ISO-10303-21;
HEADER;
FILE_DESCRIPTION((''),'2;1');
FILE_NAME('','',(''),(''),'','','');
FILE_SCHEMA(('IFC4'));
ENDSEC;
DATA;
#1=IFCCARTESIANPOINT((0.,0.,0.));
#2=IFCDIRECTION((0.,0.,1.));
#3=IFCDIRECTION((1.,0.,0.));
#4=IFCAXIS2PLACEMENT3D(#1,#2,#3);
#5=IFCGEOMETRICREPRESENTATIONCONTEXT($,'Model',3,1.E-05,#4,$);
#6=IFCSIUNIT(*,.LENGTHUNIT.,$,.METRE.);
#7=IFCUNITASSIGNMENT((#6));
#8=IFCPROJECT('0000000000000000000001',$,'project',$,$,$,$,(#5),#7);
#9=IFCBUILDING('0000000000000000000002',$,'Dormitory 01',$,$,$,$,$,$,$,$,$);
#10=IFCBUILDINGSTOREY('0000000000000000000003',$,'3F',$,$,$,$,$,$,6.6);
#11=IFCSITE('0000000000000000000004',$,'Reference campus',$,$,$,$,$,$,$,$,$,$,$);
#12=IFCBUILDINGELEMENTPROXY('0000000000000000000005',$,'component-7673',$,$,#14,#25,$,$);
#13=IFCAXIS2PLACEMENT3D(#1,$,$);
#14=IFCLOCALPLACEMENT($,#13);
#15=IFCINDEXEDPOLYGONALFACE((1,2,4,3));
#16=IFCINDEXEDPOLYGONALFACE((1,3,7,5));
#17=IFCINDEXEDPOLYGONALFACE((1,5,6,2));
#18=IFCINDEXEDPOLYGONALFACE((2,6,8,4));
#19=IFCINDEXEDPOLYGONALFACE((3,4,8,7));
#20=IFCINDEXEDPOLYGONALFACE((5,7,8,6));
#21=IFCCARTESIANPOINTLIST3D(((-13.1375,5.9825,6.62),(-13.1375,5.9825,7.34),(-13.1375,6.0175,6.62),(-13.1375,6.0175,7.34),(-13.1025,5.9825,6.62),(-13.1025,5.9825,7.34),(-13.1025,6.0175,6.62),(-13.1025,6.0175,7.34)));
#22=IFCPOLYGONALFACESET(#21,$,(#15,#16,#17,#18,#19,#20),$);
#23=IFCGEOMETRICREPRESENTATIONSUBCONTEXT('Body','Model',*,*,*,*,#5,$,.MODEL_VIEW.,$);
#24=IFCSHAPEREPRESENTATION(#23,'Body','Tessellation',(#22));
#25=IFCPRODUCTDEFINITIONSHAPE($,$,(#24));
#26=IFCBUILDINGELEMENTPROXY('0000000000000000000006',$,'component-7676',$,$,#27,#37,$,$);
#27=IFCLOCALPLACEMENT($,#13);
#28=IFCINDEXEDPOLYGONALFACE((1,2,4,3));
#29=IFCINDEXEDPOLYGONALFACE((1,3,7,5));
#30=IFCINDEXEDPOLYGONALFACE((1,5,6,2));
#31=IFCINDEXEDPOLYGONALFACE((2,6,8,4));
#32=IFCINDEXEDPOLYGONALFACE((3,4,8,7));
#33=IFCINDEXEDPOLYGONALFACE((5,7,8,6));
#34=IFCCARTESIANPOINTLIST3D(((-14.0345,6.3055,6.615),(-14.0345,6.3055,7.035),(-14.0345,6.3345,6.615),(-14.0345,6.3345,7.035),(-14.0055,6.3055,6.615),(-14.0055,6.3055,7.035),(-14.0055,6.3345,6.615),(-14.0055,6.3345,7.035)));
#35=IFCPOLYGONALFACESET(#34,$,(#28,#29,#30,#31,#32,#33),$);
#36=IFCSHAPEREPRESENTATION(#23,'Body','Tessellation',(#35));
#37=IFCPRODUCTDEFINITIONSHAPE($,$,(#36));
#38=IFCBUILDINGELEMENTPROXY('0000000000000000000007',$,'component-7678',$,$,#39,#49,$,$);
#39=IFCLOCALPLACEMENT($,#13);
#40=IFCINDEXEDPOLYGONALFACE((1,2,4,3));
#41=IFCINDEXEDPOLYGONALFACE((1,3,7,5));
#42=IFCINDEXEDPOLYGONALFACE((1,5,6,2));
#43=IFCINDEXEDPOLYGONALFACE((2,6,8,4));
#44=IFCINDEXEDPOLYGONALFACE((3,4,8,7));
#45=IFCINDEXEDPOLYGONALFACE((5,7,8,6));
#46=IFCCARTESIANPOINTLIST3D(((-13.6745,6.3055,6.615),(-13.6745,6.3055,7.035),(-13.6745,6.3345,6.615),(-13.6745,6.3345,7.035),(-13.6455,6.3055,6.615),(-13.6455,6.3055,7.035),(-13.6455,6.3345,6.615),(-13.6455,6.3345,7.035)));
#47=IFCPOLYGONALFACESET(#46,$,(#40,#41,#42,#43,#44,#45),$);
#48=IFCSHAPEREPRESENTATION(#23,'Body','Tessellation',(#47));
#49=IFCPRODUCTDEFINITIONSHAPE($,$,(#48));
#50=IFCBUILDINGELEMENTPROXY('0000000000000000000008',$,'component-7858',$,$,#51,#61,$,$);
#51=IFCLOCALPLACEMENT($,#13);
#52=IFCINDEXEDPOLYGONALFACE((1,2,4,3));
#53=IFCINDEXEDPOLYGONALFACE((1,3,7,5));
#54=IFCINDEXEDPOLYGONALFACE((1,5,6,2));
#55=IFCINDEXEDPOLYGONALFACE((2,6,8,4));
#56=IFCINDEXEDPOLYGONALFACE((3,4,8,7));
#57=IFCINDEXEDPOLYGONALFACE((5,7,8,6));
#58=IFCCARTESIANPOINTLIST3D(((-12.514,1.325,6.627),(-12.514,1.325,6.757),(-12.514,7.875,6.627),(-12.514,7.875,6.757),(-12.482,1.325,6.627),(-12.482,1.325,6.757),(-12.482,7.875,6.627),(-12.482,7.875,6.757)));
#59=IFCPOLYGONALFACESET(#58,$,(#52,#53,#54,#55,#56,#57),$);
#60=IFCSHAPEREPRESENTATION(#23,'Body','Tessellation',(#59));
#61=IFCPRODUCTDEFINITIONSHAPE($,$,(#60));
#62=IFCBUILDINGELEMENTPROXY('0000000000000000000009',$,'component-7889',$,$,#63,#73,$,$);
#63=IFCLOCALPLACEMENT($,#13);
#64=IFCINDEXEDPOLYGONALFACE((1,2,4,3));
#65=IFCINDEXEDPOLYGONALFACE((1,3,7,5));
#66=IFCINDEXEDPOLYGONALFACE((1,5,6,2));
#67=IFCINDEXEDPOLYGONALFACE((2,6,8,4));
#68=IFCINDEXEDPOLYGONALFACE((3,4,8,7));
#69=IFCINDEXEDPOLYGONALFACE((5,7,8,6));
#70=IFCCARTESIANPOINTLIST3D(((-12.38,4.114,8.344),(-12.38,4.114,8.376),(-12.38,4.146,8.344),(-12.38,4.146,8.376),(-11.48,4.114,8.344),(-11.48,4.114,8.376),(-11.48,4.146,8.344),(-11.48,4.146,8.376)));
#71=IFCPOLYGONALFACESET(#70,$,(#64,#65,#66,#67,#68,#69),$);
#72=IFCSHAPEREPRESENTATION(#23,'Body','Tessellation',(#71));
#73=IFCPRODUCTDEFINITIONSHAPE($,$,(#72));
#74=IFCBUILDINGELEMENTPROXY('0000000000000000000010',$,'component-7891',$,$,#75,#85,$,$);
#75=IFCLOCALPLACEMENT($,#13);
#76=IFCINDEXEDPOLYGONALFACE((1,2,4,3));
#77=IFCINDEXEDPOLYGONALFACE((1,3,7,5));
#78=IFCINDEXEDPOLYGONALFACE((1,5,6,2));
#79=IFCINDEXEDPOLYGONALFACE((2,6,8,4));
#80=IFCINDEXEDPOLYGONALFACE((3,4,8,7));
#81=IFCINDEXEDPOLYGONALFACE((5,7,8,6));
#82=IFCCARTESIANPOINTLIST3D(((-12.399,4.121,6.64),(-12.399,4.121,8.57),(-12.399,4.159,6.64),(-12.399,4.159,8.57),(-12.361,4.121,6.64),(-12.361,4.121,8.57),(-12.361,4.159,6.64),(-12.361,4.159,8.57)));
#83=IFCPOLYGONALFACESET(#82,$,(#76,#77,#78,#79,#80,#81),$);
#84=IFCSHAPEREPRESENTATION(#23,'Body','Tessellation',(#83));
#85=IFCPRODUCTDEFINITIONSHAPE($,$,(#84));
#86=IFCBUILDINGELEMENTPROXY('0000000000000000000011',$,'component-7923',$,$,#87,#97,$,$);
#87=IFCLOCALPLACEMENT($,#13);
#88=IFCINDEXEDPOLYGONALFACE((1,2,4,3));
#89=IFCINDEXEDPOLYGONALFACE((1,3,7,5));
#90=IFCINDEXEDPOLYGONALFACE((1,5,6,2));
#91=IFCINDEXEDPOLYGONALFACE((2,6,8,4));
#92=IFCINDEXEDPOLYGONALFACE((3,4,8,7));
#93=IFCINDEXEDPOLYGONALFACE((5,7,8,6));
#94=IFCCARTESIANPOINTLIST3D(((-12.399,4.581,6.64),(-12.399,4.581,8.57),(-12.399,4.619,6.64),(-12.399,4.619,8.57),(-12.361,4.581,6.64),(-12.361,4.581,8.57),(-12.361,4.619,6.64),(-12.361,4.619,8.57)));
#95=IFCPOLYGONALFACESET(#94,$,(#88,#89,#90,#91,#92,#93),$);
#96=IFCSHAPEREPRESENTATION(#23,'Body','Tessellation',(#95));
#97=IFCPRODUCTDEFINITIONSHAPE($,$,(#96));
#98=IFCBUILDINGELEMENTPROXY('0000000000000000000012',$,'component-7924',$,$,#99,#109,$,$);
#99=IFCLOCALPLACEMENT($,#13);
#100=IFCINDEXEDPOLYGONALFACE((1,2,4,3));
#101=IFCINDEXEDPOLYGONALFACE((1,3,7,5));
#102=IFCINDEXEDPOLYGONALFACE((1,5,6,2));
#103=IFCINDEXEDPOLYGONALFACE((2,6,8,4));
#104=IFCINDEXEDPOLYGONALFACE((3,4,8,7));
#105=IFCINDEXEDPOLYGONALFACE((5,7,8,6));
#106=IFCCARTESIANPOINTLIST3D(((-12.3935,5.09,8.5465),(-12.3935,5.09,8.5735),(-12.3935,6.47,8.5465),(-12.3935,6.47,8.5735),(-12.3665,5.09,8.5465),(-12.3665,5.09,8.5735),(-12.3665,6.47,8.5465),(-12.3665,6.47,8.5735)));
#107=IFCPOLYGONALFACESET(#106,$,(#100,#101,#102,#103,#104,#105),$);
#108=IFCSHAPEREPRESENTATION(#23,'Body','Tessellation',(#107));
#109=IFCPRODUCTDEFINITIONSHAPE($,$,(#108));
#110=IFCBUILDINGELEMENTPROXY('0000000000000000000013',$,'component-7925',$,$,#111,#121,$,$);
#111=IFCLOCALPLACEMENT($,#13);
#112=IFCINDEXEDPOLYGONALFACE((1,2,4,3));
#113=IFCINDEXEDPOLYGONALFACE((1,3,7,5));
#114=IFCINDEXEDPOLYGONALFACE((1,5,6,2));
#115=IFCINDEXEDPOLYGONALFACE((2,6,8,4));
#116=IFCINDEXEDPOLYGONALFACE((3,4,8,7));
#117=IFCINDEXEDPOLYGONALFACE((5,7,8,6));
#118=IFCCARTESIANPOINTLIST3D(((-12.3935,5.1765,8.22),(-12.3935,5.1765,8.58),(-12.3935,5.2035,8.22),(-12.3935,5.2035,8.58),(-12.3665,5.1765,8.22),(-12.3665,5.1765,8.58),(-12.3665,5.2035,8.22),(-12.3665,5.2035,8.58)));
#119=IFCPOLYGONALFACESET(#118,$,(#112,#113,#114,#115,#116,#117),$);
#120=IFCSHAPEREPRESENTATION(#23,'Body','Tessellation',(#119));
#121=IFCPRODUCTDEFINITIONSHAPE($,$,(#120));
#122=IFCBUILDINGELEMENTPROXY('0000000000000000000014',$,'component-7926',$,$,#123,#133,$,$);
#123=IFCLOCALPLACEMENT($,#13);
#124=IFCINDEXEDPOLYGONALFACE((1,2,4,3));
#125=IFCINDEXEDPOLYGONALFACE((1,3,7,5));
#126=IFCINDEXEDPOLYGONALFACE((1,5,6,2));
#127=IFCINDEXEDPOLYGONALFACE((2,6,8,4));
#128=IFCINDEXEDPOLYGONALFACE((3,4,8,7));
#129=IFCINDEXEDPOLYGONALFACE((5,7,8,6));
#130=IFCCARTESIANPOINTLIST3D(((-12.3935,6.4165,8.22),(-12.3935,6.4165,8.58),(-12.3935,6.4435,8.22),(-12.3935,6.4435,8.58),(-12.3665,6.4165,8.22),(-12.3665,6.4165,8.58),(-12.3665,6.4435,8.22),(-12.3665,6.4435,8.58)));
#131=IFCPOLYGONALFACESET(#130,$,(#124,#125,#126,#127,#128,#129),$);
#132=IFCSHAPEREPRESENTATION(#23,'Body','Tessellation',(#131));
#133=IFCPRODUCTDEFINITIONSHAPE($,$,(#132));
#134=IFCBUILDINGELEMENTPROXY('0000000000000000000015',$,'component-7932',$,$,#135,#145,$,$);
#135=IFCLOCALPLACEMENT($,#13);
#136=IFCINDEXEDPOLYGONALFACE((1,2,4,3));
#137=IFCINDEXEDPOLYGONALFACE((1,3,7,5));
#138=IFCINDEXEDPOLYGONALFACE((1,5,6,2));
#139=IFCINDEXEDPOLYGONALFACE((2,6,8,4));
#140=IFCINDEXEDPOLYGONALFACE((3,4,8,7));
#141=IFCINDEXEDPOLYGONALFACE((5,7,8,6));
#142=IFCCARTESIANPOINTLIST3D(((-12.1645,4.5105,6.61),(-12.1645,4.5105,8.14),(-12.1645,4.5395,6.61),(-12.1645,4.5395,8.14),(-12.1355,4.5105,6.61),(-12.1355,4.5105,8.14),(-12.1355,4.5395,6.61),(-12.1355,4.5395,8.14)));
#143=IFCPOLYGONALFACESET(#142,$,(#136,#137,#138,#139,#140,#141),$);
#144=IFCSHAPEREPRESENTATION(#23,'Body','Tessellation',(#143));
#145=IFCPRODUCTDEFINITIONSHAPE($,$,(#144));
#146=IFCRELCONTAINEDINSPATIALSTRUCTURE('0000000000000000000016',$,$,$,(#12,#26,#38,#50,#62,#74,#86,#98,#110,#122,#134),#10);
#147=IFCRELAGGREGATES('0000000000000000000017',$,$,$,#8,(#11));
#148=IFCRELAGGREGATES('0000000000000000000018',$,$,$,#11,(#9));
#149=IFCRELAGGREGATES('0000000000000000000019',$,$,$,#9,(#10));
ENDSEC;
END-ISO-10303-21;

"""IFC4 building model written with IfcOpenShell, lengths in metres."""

from ifc_helpers import new_model, si_unit, frame, origin, origin_with_axes, origin_2d, place, context, subcontext, project, spatial, rectangle, extrude, element, save


model = new_model("IFC4")

# Units and contexts
model_context = context("Model", 3, precision=1e-05, world=origin_with_axes())
body_context = subcontext(model_context, "Body", "Model", "MODEL_VIEW")
ifc_project = project(units=[si_unit("LENGTHUNIT", "METRE")], contexts=[model_context])

# Site, building, storey
site = spatial("IfcSite", under=ifc_project, Name="Reference campus")
building = spatial("IfcBuilding", under=site, Name="Dormitory 01")
storey = spatial("IfcBuildingStorey", under=building, Name="3F", Elevation=6.6)

# Building element proxies
for number, where, z_axis, x_axis, name in (
    (1, (-13.12, 6.0, 6.62), (0.0, 0.0, 1.0), (1.0, 0.0, 0.0), "component-7673"),
):
    element("IfcBuildingElementProxy", number, at=place(None, frame(where, z_axis=z_axis, x_axis=x_axis)), inside=storey, Name=name, context=body_context, shape_type="SweptSolid", body=[
        extrude(rectangle(XDim=0.035, YDim=0.035, at=origin_2d()), origin(), (0.0, 0.0, 1.0), 0.72),
    ])
for number, where, z_axis, x_axis, name in (
    (2, (-14.02, 6.32, 6.615), (0.0, 0.0, 1.0), (1.0, 0.0, 0.0), "component-7676"),
    (3, (-13.66, 6.32, 6.615), (0.0, 0.0, 1.0), (1.0, 0.0, 0.0), "component-7678"),
):
    element("IfcBuildingElementProxy", number, at=place(None, frame(where, z_axis=z_axis, x_axis=x_axis)), inside=storey, Name=name, context=body_context, shape_type="SweptSolid", body=[
        extrude(rectangle(XDim=0.029, YDim=0.029, at=origin_2d()), origin(), (0.0, 0.0, 1.0), 0.42),
    ])
proxy_1_placement = place(None, frame((-12.498, 4.6, 6.627), z_axis=(0.0, 0.0, 1.0), x_axis=(1.0, 0.0, 0.0)))
element("IfcBuildingElementProxy", 4, at=proxy_1_placement, inside=storey, Name="component-7858", context=body_context, shape_type="SweptSolid", body=[
    extrude(rectangle(XDim=0.032, YDim=6.55, at=origin_2d()), origin(), (0.0, 0.0, 1.0), 0.13),
])
proxy_2_placement = place(None, frame((-11.93, 4.13, 8.344), z_axis=(0.0, 0.0, 1.0), x_axis=(1.0, 0.0, 0.0)))
element("IfcBuildingElementProxy", 5, at=proxy_2_placement, inside=storey, Name="component-7889", context=body_context, shape_type="SweptSolid", body=[
    extrude(rectangle(XDim=0.9, YDim=0.032, at=origin_2d()), origin(), (0.0, 0.0, 1.0), 0.032),
])
for number, where, z_axis, x_axis, name in (
    (6, (-12.38, 4.14, 6.64), (0.0, 0.0, 1.0), (1.0, 0.0, 0.0), "component-7891"),
    (7, (-12.38, 4.6, 6.64), (0.0, 0.0, 1.0), (1.0, 0.0, 0.0), "component-7923"),
):
    element("IfcBuildingElementProxy", number, at=place(None, frame(where, z_axis=z_axis, x_axis=x_axis)), inside=storey, Name=name, context=body_context, shape_type="SweptSolid", body=[
        extrude(rectangle(XDim=0.038, YDim=0.038, at=origin_2d()), origin(), (0.0, 0.0, 1.0), 1.93),
    ])
proxy_3_placement = place(None, frame((-12.38, 5.78, 8.5465), z_axis=(0.0, 0.0, 1.0), x_axis=(1.0, 0.0, 0.0)))
element("IfcBuildingElementProxy", 8, at=proxy_3_placement, inside=storey, Name="component-7924", context=body_context, shape_type="SweptSolid", body=[
    extrude(rectangle(XDim=0.027, YDim=1.38, at=origin_2d()), origin(), (0.0, 0.0, 1.0), 0.027),
])
for number, where, z_axis, x_axis, name in (
    (9, (-12.38, 5.19, 8.22), (0.0, 0.0, 1.0), (1.0, 0.0, 0.0), "component-7925"),
    (10, (-12.38, 6.43, 8.22), (0.0, 0.0, 1.0), (1.0, 0.0, 0.0), "component-7926"),
):
    element("IfcBuildingElementProxy", number, at=place(None, frame(where, z_axis=z_axis, x_axis=x_axis)), inside=storey, Name=name, context=body_context, shape_type="SweptSolid", body=[
        extrude(rectangle(XDim=0.027, YDim=0.027, at=origin_2d()), origin(), (0.0, 0.0, 1.0), 0.36),
    ])
proxy_4_placement = place(None, frame((-12.15, 4.525, 6.61), z_axis=(0.0, 0.0, 1.0), x_axis=(1.0, 0.0, 0.0)))
element("IfcBuildingElementProxy", 11, at=proxy_4_placement, inside=storey, Name="component-7932", context=body_context, shape_type="SweptSolid", body=[
    extrude(rectangle(XDim=0.029, YDim=0.029, at=origin_2d()), origin(), (0.0, 0.0, 1.0), 1.53),
])

save(model, "model.ifc")
